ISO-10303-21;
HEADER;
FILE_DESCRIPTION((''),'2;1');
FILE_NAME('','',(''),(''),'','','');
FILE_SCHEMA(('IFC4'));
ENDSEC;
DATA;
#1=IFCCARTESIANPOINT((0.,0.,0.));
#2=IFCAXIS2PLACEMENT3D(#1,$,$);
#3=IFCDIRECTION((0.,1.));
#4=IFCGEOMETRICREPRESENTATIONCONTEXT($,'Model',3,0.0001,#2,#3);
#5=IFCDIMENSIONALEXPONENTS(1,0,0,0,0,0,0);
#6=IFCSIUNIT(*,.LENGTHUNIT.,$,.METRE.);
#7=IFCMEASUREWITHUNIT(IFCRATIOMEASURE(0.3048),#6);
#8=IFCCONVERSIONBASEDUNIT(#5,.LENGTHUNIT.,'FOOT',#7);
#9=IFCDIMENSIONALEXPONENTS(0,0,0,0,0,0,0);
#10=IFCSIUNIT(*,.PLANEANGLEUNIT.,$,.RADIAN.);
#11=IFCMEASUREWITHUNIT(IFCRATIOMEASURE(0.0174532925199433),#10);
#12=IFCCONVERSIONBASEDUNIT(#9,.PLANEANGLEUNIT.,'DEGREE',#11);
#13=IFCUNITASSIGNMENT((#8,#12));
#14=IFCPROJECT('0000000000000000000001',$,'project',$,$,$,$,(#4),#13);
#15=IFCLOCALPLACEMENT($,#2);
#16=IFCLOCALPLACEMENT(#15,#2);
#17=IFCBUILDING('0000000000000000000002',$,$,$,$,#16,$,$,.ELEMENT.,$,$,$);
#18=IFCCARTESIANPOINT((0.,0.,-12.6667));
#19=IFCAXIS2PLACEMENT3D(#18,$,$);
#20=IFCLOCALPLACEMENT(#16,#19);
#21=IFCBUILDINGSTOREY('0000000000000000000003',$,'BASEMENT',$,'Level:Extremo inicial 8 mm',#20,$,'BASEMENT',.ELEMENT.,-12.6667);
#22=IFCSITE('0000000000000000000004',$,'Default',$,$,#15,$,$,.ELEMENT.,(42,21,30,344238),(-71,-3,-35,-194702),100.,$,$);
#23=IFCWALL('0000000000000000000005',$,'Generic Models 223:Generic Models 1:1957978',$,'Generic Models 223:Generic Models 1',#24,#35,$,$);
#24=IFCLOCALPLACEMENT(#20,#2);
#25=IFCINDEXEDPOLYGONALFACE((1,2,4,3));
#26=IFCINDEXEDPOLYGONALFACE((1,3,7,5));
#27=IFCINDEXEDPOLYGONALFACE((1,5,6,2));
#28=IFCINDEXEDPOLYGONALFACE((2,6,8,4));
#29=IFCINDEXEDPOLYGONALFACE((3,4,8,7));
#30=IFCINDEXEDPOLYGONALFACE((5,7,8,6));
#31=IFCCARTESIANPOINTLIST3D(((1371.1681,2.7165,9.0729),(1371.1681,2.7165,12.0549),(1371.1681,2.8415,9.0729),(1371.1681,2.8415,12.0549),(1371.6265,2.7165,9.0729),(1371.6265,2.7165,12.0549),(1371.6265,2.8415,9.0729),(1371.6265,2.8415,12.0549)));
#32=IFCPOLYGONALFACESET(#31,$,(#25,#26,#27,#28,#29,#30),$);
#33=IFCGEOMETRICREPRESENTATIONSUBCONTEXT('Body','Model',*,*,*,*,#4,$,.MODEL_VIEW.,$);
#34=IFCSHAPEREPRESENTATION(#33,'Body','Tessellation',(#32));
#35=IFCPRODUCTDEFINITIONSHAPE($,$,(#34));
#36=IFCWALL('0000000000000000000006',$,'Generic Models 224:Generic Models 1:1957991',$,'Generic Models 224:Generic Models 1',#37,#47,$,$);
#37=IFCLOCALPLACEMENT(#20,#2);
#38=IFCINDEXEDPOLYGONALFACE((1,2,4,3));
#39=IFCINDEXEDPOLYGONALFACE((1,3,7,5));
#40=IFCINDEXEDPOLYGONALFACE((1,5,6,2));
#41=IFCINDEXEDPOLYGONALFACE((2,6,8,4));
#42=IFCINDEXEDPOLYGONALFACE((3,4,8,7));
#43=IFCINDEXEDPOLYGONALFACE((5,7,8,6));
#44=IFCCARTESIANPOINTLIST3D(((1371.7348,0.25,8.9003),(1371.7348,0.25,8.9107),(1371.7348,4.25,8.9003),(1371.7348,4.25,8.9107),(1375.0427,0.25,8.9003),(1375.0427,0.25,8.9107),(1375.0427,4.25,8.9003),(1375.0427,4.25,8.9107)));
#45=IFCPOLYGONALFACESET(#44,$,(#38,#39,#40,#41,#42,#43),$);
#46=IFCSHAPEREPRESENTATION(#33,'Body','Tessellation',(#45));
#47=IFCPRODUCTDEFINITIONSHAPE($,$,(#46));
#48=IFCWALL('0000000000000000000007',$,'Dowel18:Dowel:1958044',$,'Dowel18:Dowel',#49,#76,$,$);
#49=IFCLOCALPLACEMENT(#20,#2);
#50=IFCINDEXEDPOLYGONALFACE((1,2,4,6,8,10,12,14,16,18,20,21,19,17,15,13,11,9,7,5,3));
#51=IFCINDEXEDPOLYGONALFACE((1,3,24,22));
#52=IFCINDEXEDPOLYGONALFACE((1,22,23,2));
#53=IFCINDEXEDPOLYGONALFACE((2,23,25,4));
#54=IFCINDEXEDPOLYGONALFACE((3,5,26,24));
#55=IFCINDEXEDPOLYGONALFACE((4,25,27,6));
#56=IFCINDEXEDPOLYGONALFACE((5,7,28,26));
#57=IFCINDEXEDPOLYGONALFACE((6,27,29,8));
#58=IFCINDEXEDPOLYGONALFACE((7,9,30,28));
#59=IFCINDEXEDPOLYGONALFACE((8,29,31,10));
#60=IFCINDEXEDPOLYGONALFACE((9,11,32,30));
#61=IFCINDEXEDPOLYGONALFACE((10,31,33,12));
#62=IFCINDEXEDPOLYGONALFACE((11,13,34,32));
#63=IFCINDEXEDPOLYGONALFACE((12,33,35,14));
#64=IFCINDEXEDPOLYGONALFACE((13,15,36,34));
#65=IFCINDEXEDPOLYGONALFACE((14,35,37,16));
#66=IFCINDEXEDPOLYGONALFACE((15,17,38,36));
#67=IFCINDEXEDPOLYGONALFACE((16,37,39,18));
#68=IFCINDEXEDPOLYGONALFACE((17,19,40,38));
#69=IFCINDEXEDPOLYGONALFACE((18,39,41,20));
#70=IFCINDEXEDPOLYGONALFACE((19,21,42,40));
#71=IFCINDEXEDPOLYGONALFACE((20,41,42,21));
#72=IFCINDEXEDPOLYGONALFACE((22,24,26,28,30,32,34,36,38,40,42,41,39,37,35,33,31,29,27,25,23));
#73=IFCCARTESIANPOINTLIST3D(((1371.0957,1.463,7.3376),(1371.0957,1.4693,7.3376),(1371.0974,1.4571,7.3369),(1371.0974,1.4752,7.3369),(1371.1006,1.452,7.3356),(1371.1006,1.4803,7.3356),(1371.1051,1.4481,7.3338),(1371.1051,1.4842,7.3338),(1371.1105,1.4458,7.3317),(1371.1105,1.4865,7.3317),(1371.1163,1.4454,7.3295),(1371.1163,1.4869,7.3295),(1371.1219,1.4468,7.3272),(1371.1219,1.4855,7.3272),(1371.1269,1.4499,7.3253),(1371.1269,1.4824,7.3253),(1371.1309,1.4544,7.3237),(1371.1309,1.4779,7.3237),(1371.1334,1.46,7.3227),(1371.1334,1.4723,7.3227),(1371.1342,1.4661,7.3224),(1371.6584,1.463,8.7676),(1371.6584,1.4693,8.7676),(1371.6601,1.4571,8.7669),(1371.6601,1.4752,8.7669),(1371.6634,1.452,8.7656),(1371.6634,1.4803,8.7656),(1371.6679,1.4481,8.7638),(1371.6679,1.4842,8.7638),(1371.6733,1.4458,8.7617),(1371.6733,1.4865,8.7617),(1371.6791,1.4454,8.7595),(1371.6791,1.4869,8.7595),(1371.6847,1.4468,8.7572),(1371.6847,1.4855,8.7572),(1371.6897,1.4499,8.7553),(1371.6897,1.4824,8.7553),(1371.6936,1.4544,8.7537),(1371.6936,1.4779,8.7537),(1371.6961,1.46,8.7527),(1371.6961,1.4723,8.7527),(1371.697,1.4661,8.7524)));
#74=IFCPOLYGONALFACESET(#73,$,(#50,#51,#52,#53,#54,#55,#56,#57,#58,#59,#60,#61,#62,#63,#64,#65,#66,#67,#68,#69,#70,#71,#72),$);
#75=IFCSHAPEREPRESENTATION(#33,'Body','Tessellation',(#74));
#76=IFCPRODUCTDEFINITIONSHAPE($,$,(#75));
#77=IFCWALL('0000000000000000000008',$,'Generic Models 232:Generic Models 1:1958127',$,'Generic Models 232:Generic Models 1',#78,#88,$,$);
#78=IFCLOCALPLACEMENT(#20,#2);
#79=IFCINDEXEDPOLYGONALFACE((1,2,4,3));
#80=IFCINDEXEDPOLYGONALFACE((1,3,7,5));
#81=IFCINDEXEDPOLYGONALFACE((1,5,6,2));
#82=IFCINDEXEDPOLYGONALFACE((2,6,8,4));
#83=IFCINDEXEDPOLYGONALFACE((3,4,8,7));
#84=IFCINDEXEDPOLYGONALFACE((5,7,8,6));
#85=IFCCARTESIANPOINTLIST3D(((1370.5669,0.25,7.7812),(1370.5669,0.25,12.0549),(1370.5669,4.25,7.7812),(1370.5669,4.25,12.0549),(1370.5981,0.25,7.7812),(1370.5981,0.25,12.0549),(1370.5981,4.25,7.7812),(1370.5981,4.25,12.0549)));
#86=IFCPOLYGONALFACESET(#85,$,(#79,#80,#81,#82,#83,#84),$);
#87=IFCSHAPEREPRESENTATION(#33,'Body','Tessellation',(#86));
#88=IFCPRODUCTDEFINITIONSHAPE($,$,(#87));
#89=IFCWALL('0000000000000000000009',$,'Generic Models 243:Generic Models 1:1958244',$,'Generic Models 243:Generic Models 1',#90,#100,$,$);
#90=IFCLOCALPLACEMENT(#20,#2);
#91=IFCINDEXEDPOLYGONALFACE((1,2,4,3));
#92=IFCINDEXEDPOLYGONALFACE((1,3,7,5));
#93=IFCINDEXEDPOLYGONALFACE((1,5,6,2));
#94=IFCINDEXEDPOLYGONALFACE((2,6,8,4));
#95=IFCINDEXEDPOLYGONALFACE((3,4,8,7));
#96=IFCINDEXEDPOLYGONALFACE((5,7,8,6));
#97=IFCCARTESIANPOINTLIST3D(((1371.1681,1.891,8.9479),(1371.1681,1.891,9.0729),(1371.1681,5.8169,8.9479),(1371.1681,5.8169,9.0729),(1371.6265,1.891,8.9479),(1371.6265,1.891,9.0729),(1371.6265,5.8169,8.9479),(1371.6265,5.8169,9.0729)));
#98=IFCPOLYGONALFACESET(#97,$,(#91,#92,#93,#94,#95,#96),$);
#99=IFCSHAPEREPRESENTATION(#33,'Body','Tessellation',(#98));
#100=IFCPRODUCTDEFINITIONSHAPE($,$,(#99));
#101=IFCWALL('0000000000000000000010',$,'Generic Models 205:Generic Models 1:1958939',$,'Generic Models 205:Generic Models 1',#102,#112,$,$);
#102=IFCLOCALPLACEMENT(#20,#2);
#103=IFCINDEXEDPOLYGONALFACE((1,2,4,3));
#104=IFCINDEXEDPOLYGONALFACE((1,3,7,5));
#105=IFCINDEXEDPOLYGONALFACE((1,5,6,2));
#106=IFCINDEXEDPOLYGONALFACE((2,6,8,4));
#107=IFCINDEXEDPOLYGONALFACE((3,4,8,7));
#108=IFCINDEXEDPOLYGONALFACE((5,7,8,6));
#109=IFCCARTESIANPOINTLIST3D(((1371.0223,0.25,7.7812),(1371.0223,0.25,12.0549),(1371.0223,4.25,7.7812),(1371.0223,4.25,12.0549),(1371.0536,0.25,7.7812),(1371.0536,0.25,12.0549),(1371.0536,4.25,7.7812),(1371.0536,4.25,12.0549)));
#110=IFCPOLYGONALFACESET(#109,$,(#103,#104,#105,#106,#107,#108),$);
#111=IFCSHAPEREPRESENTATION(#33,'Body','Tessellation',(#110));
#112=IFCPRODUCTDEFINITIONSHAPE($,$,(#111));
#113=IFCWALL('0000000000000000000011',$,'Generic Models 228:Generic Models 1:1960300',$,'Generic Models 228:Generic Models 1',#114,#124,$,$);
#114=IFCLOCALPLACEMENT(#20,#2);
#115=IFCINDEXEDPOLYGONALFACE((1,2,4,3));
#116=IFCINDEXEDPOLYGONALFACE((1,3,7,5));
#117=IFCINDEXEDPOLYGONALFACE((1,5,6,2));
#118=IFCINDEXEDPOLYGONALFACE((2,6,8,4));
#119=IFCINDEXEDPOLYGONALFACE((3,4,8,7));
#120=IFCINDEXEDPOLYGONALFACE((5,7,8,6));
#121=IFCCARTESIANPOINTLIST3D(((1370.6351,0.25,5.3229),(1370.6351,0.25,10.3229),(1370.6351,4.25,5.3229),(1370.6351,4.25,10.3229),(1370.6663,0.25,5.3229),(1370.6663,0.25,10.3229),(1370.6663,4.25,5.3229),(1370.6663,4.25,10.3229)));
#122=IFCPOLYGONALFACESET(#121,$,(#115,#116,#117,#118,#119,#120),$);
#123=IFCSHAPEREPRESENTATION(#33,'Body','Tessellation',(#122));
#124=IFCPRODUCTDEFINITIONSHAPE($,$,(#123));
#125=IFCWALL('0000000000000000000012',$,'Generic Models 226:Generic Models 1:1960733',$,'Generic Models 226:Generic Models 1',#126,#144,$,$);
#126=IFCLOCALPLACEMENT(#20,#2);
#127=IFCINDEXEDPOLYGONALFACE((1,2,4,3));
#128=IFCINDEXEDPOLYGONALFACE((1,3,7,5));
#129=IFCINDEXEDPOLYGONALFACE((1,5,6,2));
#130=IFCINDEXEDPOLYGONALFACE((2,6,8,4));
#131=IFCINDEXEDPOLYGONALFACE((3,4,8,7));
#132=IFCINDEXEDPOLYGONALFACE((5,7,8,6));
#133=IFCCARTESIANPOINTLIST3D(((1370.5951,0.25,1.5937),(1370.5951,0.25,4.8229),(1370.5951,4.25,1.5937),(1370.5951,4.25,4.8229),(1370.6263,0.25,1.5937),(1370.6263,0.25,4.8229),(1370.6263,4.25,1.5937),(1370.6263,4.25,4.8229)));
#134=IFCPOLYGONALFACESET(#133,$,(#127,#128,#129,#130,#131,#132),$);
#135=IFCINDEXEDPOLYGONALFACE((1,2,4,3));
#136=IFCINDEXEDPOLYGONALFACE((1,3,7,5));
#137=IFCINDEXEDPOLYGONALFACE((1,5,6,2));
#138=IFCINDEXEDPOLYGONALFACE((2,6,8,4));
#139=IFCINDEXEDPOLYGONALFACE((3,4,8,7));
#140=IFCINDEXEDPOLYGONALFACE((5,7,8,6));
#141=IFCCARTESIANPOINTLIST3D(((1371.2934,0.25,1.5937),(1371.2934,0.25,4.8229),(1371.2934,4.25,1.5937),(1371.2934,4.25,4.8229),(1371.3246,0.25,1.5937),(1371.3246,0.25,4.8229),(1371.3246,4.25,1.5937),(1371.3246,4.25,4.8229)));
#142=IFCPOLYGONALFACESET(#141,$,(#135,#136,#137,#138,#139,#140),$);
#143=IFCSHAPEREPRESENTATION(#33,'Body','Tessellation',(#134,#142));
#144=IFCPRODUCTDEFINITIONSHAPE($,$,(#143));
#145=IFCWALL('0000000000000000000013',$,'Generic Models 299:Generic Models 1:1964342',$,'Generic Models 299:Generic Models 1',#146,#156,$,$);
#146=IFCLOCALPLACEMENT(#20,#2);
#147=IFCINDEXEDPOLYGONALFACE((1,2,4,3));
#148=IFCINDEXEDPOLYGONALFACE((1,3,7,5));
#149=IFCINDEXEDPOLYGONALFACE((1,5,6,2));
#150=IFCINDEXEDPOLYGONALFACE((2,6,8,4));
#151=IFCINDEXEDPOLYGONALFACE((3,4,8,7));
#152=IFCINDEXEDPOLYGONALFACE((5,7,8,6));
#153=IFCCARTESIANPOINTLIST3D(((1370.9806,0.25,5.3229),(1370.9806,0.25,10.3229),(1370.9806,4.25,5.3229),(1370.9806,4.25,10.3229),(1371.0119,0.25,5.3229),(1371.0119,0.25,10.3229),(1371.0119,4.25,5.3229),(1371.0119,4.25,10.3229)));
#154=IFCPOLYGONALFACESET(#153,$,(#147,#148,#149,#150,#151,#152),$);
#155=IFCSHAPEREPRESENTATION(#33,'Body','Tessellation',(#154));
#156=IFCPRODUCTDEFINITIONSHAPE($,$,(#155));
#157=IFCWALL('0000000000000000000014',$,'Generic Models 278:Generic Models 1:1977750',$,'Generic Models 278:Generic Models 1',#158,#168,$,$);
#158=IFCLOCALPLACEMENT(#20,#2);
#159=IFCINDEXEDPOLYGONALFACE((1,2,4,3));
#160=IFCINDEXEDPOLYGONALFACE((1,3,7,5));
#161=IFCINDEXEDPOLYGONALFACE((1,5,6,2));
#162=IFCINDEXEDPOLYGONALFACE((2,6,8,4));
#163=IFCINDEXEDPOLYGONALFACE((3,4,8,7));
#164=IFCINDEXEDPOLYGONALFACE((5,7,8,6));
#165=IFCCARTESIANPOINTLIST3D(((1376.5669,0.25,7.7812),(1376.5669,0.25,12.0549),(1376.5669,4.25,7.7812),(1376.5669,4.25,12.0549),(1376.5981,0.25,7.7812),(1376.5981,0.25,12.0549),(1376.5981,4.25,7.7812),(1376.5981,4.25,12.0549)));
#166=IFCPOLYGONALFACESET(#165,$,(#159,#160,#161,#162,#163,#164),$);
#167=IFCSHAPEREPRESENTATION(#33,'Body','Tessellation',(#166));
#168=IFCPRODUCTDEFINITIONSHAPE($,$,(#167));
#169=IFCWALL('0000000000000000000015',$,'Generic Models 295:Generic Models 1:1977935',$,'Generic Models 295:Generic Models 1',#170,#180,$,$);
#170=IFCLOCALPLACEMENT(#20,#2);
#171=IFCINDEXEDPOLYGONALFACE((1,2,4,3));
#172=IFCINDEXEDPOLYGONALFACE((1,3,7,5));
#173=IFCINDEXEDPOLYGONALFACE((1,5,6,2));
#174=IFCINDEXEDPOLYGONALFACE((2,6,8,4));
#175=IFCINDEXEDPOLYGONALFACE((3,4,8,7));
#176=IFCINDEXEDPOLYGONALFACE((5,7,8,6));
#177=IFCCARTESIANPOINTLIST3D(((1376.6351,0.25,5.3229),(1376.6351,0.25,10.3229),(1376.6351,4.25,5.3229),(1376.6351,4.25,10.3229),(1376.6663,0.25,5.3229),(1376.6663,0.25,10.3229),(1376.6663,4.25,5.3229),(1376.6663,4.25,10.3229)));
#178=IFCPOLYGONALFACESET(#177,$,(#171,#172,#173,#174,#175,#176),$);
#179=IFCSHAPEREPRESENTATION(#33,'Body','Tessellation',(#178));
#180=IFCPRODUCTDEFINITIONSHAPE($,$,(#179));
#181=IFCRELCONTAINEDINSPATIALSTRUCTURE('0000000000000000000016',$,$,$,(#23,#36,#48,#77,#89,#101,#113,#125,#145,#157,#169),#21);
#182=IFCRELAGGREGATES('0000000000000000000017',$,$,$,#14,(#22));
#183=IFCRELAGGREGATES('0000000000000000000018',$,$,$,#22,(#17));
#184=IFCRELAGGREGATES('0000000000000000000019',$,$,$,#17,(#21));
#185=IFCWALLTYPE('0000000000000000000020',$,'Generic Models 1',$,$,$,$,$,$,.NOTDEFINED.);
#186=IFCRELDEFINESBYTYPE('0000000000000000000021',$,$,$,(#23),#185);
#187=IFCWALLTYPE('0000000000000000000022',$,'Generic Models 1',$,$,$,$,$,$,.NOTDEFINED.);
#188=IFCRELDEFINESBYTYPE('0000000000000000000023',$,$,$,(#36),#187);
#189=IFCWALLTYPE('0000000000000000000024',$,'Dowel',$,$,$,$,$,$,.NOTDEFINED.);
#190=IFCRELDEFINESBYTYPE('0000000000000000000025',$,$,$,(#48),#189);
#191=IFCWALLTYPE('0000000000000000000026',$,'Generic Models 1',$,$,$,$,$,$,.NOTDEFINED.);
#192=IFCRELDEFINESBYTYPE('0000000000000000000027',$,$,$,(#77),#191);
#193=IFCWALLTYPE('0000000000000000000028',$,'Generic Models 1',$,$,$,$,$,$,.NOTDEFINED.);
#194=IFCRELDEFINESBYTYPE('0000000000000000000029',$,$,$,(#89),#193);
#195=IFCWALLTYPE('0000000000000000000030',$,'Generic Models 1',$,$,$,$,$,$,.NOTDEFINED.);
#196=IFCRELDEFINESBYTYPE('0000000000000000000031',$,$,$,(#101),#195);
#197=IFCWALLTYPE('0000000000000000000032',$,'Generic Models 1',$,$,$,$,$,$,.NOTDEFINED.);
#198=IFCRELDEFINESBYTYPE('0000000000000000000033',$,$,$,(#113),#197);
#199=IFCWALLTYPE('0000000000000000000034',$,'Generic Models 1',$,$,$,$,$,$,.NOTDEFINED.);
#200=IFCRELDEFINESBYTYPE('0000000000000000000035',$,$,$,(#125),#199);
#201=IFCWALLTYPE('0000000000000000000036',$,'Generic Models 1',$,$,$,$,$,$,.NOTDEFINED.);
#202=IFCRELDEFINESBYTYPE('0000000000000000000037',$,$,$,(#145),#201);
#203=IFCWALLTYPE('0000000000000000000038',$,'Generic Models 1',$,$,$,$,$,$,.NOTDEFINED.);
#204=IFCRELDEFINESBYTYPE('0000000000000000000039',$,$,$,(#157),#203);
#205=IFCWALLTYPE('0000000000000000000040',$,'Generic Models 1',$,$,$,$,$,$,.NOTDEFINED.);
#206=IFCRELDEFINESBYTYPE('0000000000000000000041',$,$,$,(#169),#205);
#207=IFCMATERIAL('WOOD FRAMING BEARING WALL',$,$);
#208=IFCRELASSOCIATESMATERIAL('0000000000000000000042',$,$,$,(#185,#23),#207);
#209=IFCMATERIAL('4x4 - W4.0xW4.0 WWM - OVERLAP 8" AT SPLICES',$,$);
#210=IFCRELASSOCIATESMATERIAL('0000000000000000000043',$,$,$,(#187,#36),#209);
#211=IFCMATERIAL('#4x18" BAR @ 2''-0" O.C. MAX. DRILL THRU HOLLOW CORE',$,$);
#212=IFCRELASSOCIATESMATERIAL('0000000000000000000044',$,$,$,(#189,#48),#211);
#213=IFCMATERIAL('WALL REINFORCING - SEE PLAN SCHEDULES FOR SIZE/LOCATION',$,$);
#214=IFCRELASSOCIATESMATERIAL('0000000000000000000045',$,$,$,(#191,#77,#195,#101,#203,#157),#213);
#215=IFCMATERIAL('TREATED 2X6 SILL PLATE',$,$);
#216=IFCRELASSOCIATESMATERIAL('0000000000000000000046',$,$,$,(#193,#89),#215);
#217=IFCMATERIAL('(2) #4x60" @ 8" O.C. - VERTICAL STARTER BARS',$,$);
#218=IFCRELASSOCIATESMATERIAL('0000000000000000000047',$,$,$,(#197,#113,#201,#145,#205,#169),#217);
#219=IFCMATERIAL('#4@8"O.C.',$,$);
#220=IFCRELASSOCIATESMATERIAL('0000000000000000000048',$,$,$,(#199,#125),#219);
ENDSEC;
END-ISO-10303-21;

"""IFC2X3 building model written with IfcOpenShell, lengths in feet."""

from ifc_helpers import new_model, entity, si_unit, converted_unit, direction, frame, frame_2d, origin, place, context, subcontext, project, spatial, rectangle, circle, extrude, material, type_object, element, save


model = new_model("IFC2X3")

# Units and contexts
model_context = context("Model", 3, precision=0.0001, world=origin(), true_north=direction((0.0, 1.0)))
body_context = subcontext(model_context, "Body", "Model", "MODEL_VIEW")
ifc_project = project(units=[converted_unit("LENGTHUNIT", "FOOT", entity("IfcRatioMeasure", 0.3048), si_unit("LENGTHUNIT", "METRE"), dimensions=[1, 0, 0, 0, 0, 0, 0]), converted_unit("PLANEANGLEUNIT", "DEGREE", entity("IfcRatioMeasure", 0.0174532925199433), si_unit("PLANEANGLEUNIT", "RADIAN"), dimensions=[0, 0, 0, 0, 0, 0, 0])], contexts=[model_context])

# Site, building, storey
site_placement = place(None, origin())
site = spatial("IfcSite", under=ifc_project, at=site_placement, Name="Default", CompositionType="ELEMENT", RefLatitude=(42, 21, 30, 344238), RefLongitude=(-71, -3, -35, -194702), RefElevation=100.0)
building_placement = place(site_placement, origin())
building = spatial("IfcBuilding", under=site, at=building_placement, CompositionType="ELEMENT")
storey_placement = place(building_placement, frame((0.0, 0.0, -12.6667)))
storey = spatial("IfcBuildingStorey", under=building, at=storey_placement, Name="BASEMENT", ObjectType="Level:Extremo inicial 8 mm", LongName="BASEMENT", CompositionType="ELEMENT", Elevation=-12.6667)

# Walls
ifc_material_1 = material(Name="TREATED 2X6 SILL PLATE")
ifc_material_2 = material(Name="WOOD FRAMING BEARING WALL")
ifc_material_3 = material(Name="4x4 - W4.0xW4.0 WWM - OVERLAP 8\" AT SPLICES")
ifc_material_4 = material(Name="#4x18\" BAR @ 2'-0\" O.C. MAX. DRILL THRU HOLLOW CORE")
wall_type_1 = type_object("IfcWallType", Name="Generic Models 1", PredefinedType="NOTDEFINED", material=ifc_material_2)
wall_1_placement = place(storey_placement, frame((1371.1681, 2.7165, 9.0729)))
element("IfcWall", 1, at=wall_1_placement, inside=storey, type_object=wall_type_1, material=ifc_material_2, Name="Generic Models 223:Generic Models 1:1957978", ObjectType="Generic Models 223:Generic Models 1", context=body_context, shape_type="SweptSolid", body=[
    extrude(rectangle(XDim=0.125, YDim=0.4583, at=frame_2d((0.0, 0.0), x_axis=(1.0, 0.0))), frame((0.2292, 0.0625, 0.0), z_axis=(0.0, 0.0, 1.0), x_axis=(0.0, 1.0, 0.0)), (0.0, 0.0, 1.0), 2.982),
])
wall_type_2 = type_object("IfcWallType", Name="Generic Models 1", PredefinedType="NOTDEFINED", material=ifc_material_3)
wall_2_placement = place(storey_placement, frame((1371.7348, 0.25, 8.9003), z_axis=(0.0, 0.0, 1.0), x_axis=(0.0, 1.0, 0.0)))
element("IfcWall", 2, at=wall_2_placement, inside=storey, type_object=wall_type_2, material=ifc_material_3, Name="Generic Models 224:Generic Models 1:1957991", ObjectType="Generic Models 224:Generic Models 1", context=body_context, shape_type="SweptSolid", body=[
    extrude(rectangle(XDim=4.0, YDim=3.3079, at=frame_2d((0.0, 0.0), x_axis=(1.0, 0.0))), frame((2.0, -1.654, 0.0)), (0.0, 0.0, 1.0), 0.0104),
])
wall_type_3 = type_object("IfcWallType", Name="Dowel", PredefinedType="NOTDEFINED", material=ifc_material_4)
wall_3_placement = place(storey_placement, frame((1371.0955, 1.4453, 7.3224)))
element("IfcWall", 3, at=wall_3_placement, inside=storey, type_object=wall_type_3, material=ifc_material_4, Name="Dowel18:Dowel:1958044", ObjectType="Dowel18:Dowel", context=body_context, shape_type="SweptSolid", body=[
    extrude(circle(Radius=0.0208, at=frame_2d((0.0, 0.0), x_axis=(1.0, 0.0))), frame((0.0194, 0.0208, 0.0076), z_axis=(0.36621, 0.0, 0.930532), x_axis=(0.930532, 0.0, -0.36621)), (0.0, 0.0, 1.0), 1.5368),
])
ifc_material_5 = material(Name="WALL REINFORCING - SEE PLAN SCHEDULES FOR SIZE/LOCATION")
wall_type_4 = type_object("IfcWallType", Name="Generic Models 1", PredefinedType="NOTDEFINED", material=ifc_material_5)
wall_4_placement = place(storey_placement, frame((1370.5669, 0.25, 7.7812), z_axis=(0.0, 0.0, 1.0), x_axis=(0.0, 1.0, 0.0)))
element("IfcWall", 4, at=wall_4_placement, inside=storey, type_object=wall_type_4, material=ifc_material_5, Name="Generic Models 232:Generic Models 1:1958127", ObjectType="Generic Models 232:Generic Models 1", context=body_context, shape_type="SweptSolid", body=[
    extrude(rectangle(XDim=4.0, YDim=0.0312, at=frame_2d((0.0, 0.0), x_axis=(1.0, 0.0))), frame((2.0, -0.0156, 0.0)), (0.0, 0.0, 1.0), 4.2736),
])
wall_type_5 = type_object("IfcWallType", Name="Generic Models 1", PredefinedType="NOTDEFINED", material=ifc_material_1)
wall_5_placement = place(storey_placement, frame((1371.1681, 1.891, 8.9479), z_axis=(0.0, 0.0, 1.0), x_axis=(0.0, 1.0, 0.0)))
element("IfcWall", 5, at=wall_5_placement, inside=storey, type_object=wall_type_5, material=ifc_material_1, Name="Generic Models 243:Generic Models 1:1958244", ObjectType="Generic Models 243:Generic Models 1", context=body_context, shape_type="SweptSolid", body=[
    extrude(rectangle(XDim=3.9258, YDim=0.4583, at=frame_2d((0.0, 0.0), x_axis=(1.0, 0.0))), frame((1.9629, -0.2292, 0.0)), (0.0, 0.0, 1.0), 0.125),
])
wall_type_6 = type_object("IfcWallType", Name="Generic Models 1", PredefinedType="NOTDEFINED", material=ifc_material_5)
wall_6_placement = place(storey_placement, frame((1371.0223, 0.25, 7.7812), z_axis=(0.0, 0.0, 1.0), x_axis=(0.0, 1.0, 0.0)))
element("IfcWall", 6, at=wall_6_placement, inside=storey, type_object=wall_type_6, material=ifc_material_5, Name="Generic Models 205:Generic Models 1:1958939", ObjectType="Generic Models 205:Generic Models 1", context=body_context, shape_type="SweptSolid", body=[
    extrude(rectangle(XDim=4.0, YDim=0.0312, at=frame_2d((0.0, 0.0), x_axis=(1.0, 0.0))), frame((2.0, -0.0156, 0.0)), (0.0, 0.0, 1.0), 4.2736),
])
ifc_material_6 = material(Name="(2) #4x60\" @ 8\" O.C. - VERTICAL STARTER BARS")
wall_type_7 = type_object("IfcWallType", Name="Generic Models 1", PredefinedType="NOTDEFINED", material=ifc_material_6)
wall_7_placement = place(storey_placement, frame((1370.6351, 0.25, 5.3229), z_axis=(0.0, 0.0, 1.0), x_axis=(0.0, 1.0, 0.0)))
element("IfcWall", 7, at=wall_7_placement, inside=storey, type_object=wall_type_7, material=ifc_material_6, Name="Generic Models 228:Generic Models 1:1960300", ObjectType="Generic Models 228:Generic Models 1", context=body_context, shape_type="SweptSolid", body=[
    extrude(rectangle(XDim=4.0, YDim=0.0312, at=frame_2d((0.0, 0.0), x_axis=(1.0, 0.0))), frame((2.0, -0.0156, 0.0)), (0.0, 0.0, 1.0), 5.0),
])
ifc_material_7 = material(Name="#4@8\"O.C.")
wall_type_8 = type_object("IfcWallType", Name="Generic Models 1", PredefinedType="NOTDEFINED", material=ifc_material_7)
wall_8_placement = place(storey_placement, frame((1370.5951, 0.25, 1.5937), z_axis=(0.0, 0.0, 1.0), x_axis=(0.0, 1.0, 0.0)))
element("IfcWall", 8, at=wall_8_placement, inside=storey, type_object=wall_type_8, material=ifc_material_7, Name="Generic Models 226:Generic Models 1:1960733", ObjectType="Generic Models 226:Generic Models 1", context=body_context, shape_type="SweptSolid", body=[
    extrude(rectangle(XDim=4.0, YDim=0.0312, at=frame_2d((0.0, 0.0), x_axis=(1.0, 0.0))), frame((2.0, -0.0156, 0.0)), (0.0, 0.0, 1.0), 3.2292),
    extrude(rectangle(XDim=4.0, YDim=0.0312, at=frame_2d((0.0, 0.0), x_axis=(1.0, 0.0))), frame((2.0, -0.7139, 0.0)), (0.0, 0.0, 1.0), 3.2292),
])
wall_type_9 = type_object("IfcWallType", Name="Generic Models 1", PredefinedType="NOTDEFINED", material=ifc_material_6)
wall_9_placement = place(storey_placement, frame((1370.9806, 0.25, 5.3229), z_axis=(0.0, 0.0, 1.0), x_axis=(0.0, 1.0, 0.0)))
element("IfcWall", 9, at=wall_9_placement, inside=storey, type_object=wall_type_9, material=ifc_material_6, Name="Generic Models 299:Generic Models 1:1964342", ObjectType="Generic Models 299:Generic Models 1", context=body_context, shape_type="SweptSolid", body=[
    extrude(rectangle(XDim=4.0, YDim=0.0312, at=frame_2d((0.0, 0.0), x_axis=(1.0, 0.0))), frame((2.0, -0.0156, 0.0)), (0.0, 0.0, 1.0), 5.0),
])
wall_type_10 = type_object("IfcWallType", Name="Generic Models 1", PredefinedType="NOTDEFINED", material=ifc_material_5)
wall_10_placement = place(storey_placement, frame((1376.5669, 0.25, 7.7812), z_axis=(0.0, 0.0, 1.0), x_axis=(0.0, 1.0, 0.0)))
element("IfcWall", 10, at=wall_10_placement, inside=storey, type_object=wall_type_10, material=ifc_material_5, Name="Generic Models 278:Generic Models 1:1977750", ObjectType="Generic Models 278:Generic Models 1", context=body_context, shape_type="SweptSolid", body=[
    extrude(rectangle(XDim=4.0, YDim=0.0312, at=frame_2d((0.0, 0.0), x_axis=(1.0, 0.0))), frame((2.0, -0.0156, 0.0)), (0.0, 0.0, 1.0), 4.2736),
])
wall_type_11 = type_object("IfcWallType", Name="Generic Models 1", PredefinedType="NOTDEFINED", material=ifc_material_6)
wall_11_placement = place(storey_placement, frame((1376.6351, 0.25, 5.3229), z_axis=(0.0, 0.0, 1.0), x_axis=(0.0, 1.0, 0.0)))
element("IfcWall", 11, at=wall_11_placement, inside=storey, type_object=wall_type_11, material=ifc_material_6, Name="Generic Models 295:Generic Models 1:1977935", ObjectType="Generic Models 295:Generic Models 1", context=body_context, shape_type="SweptSolid", body=[
    extrude(rectangle(XDim=4.0, YDim=0.0312, at=frame_2d((0.0, 0.0), x_axis=(1.0, 0.0))), frame((2.0, -0.0156, 0.0)), (0.0, 0.0, 1.0), 5.0),
])

save(model, "model.ifc")
